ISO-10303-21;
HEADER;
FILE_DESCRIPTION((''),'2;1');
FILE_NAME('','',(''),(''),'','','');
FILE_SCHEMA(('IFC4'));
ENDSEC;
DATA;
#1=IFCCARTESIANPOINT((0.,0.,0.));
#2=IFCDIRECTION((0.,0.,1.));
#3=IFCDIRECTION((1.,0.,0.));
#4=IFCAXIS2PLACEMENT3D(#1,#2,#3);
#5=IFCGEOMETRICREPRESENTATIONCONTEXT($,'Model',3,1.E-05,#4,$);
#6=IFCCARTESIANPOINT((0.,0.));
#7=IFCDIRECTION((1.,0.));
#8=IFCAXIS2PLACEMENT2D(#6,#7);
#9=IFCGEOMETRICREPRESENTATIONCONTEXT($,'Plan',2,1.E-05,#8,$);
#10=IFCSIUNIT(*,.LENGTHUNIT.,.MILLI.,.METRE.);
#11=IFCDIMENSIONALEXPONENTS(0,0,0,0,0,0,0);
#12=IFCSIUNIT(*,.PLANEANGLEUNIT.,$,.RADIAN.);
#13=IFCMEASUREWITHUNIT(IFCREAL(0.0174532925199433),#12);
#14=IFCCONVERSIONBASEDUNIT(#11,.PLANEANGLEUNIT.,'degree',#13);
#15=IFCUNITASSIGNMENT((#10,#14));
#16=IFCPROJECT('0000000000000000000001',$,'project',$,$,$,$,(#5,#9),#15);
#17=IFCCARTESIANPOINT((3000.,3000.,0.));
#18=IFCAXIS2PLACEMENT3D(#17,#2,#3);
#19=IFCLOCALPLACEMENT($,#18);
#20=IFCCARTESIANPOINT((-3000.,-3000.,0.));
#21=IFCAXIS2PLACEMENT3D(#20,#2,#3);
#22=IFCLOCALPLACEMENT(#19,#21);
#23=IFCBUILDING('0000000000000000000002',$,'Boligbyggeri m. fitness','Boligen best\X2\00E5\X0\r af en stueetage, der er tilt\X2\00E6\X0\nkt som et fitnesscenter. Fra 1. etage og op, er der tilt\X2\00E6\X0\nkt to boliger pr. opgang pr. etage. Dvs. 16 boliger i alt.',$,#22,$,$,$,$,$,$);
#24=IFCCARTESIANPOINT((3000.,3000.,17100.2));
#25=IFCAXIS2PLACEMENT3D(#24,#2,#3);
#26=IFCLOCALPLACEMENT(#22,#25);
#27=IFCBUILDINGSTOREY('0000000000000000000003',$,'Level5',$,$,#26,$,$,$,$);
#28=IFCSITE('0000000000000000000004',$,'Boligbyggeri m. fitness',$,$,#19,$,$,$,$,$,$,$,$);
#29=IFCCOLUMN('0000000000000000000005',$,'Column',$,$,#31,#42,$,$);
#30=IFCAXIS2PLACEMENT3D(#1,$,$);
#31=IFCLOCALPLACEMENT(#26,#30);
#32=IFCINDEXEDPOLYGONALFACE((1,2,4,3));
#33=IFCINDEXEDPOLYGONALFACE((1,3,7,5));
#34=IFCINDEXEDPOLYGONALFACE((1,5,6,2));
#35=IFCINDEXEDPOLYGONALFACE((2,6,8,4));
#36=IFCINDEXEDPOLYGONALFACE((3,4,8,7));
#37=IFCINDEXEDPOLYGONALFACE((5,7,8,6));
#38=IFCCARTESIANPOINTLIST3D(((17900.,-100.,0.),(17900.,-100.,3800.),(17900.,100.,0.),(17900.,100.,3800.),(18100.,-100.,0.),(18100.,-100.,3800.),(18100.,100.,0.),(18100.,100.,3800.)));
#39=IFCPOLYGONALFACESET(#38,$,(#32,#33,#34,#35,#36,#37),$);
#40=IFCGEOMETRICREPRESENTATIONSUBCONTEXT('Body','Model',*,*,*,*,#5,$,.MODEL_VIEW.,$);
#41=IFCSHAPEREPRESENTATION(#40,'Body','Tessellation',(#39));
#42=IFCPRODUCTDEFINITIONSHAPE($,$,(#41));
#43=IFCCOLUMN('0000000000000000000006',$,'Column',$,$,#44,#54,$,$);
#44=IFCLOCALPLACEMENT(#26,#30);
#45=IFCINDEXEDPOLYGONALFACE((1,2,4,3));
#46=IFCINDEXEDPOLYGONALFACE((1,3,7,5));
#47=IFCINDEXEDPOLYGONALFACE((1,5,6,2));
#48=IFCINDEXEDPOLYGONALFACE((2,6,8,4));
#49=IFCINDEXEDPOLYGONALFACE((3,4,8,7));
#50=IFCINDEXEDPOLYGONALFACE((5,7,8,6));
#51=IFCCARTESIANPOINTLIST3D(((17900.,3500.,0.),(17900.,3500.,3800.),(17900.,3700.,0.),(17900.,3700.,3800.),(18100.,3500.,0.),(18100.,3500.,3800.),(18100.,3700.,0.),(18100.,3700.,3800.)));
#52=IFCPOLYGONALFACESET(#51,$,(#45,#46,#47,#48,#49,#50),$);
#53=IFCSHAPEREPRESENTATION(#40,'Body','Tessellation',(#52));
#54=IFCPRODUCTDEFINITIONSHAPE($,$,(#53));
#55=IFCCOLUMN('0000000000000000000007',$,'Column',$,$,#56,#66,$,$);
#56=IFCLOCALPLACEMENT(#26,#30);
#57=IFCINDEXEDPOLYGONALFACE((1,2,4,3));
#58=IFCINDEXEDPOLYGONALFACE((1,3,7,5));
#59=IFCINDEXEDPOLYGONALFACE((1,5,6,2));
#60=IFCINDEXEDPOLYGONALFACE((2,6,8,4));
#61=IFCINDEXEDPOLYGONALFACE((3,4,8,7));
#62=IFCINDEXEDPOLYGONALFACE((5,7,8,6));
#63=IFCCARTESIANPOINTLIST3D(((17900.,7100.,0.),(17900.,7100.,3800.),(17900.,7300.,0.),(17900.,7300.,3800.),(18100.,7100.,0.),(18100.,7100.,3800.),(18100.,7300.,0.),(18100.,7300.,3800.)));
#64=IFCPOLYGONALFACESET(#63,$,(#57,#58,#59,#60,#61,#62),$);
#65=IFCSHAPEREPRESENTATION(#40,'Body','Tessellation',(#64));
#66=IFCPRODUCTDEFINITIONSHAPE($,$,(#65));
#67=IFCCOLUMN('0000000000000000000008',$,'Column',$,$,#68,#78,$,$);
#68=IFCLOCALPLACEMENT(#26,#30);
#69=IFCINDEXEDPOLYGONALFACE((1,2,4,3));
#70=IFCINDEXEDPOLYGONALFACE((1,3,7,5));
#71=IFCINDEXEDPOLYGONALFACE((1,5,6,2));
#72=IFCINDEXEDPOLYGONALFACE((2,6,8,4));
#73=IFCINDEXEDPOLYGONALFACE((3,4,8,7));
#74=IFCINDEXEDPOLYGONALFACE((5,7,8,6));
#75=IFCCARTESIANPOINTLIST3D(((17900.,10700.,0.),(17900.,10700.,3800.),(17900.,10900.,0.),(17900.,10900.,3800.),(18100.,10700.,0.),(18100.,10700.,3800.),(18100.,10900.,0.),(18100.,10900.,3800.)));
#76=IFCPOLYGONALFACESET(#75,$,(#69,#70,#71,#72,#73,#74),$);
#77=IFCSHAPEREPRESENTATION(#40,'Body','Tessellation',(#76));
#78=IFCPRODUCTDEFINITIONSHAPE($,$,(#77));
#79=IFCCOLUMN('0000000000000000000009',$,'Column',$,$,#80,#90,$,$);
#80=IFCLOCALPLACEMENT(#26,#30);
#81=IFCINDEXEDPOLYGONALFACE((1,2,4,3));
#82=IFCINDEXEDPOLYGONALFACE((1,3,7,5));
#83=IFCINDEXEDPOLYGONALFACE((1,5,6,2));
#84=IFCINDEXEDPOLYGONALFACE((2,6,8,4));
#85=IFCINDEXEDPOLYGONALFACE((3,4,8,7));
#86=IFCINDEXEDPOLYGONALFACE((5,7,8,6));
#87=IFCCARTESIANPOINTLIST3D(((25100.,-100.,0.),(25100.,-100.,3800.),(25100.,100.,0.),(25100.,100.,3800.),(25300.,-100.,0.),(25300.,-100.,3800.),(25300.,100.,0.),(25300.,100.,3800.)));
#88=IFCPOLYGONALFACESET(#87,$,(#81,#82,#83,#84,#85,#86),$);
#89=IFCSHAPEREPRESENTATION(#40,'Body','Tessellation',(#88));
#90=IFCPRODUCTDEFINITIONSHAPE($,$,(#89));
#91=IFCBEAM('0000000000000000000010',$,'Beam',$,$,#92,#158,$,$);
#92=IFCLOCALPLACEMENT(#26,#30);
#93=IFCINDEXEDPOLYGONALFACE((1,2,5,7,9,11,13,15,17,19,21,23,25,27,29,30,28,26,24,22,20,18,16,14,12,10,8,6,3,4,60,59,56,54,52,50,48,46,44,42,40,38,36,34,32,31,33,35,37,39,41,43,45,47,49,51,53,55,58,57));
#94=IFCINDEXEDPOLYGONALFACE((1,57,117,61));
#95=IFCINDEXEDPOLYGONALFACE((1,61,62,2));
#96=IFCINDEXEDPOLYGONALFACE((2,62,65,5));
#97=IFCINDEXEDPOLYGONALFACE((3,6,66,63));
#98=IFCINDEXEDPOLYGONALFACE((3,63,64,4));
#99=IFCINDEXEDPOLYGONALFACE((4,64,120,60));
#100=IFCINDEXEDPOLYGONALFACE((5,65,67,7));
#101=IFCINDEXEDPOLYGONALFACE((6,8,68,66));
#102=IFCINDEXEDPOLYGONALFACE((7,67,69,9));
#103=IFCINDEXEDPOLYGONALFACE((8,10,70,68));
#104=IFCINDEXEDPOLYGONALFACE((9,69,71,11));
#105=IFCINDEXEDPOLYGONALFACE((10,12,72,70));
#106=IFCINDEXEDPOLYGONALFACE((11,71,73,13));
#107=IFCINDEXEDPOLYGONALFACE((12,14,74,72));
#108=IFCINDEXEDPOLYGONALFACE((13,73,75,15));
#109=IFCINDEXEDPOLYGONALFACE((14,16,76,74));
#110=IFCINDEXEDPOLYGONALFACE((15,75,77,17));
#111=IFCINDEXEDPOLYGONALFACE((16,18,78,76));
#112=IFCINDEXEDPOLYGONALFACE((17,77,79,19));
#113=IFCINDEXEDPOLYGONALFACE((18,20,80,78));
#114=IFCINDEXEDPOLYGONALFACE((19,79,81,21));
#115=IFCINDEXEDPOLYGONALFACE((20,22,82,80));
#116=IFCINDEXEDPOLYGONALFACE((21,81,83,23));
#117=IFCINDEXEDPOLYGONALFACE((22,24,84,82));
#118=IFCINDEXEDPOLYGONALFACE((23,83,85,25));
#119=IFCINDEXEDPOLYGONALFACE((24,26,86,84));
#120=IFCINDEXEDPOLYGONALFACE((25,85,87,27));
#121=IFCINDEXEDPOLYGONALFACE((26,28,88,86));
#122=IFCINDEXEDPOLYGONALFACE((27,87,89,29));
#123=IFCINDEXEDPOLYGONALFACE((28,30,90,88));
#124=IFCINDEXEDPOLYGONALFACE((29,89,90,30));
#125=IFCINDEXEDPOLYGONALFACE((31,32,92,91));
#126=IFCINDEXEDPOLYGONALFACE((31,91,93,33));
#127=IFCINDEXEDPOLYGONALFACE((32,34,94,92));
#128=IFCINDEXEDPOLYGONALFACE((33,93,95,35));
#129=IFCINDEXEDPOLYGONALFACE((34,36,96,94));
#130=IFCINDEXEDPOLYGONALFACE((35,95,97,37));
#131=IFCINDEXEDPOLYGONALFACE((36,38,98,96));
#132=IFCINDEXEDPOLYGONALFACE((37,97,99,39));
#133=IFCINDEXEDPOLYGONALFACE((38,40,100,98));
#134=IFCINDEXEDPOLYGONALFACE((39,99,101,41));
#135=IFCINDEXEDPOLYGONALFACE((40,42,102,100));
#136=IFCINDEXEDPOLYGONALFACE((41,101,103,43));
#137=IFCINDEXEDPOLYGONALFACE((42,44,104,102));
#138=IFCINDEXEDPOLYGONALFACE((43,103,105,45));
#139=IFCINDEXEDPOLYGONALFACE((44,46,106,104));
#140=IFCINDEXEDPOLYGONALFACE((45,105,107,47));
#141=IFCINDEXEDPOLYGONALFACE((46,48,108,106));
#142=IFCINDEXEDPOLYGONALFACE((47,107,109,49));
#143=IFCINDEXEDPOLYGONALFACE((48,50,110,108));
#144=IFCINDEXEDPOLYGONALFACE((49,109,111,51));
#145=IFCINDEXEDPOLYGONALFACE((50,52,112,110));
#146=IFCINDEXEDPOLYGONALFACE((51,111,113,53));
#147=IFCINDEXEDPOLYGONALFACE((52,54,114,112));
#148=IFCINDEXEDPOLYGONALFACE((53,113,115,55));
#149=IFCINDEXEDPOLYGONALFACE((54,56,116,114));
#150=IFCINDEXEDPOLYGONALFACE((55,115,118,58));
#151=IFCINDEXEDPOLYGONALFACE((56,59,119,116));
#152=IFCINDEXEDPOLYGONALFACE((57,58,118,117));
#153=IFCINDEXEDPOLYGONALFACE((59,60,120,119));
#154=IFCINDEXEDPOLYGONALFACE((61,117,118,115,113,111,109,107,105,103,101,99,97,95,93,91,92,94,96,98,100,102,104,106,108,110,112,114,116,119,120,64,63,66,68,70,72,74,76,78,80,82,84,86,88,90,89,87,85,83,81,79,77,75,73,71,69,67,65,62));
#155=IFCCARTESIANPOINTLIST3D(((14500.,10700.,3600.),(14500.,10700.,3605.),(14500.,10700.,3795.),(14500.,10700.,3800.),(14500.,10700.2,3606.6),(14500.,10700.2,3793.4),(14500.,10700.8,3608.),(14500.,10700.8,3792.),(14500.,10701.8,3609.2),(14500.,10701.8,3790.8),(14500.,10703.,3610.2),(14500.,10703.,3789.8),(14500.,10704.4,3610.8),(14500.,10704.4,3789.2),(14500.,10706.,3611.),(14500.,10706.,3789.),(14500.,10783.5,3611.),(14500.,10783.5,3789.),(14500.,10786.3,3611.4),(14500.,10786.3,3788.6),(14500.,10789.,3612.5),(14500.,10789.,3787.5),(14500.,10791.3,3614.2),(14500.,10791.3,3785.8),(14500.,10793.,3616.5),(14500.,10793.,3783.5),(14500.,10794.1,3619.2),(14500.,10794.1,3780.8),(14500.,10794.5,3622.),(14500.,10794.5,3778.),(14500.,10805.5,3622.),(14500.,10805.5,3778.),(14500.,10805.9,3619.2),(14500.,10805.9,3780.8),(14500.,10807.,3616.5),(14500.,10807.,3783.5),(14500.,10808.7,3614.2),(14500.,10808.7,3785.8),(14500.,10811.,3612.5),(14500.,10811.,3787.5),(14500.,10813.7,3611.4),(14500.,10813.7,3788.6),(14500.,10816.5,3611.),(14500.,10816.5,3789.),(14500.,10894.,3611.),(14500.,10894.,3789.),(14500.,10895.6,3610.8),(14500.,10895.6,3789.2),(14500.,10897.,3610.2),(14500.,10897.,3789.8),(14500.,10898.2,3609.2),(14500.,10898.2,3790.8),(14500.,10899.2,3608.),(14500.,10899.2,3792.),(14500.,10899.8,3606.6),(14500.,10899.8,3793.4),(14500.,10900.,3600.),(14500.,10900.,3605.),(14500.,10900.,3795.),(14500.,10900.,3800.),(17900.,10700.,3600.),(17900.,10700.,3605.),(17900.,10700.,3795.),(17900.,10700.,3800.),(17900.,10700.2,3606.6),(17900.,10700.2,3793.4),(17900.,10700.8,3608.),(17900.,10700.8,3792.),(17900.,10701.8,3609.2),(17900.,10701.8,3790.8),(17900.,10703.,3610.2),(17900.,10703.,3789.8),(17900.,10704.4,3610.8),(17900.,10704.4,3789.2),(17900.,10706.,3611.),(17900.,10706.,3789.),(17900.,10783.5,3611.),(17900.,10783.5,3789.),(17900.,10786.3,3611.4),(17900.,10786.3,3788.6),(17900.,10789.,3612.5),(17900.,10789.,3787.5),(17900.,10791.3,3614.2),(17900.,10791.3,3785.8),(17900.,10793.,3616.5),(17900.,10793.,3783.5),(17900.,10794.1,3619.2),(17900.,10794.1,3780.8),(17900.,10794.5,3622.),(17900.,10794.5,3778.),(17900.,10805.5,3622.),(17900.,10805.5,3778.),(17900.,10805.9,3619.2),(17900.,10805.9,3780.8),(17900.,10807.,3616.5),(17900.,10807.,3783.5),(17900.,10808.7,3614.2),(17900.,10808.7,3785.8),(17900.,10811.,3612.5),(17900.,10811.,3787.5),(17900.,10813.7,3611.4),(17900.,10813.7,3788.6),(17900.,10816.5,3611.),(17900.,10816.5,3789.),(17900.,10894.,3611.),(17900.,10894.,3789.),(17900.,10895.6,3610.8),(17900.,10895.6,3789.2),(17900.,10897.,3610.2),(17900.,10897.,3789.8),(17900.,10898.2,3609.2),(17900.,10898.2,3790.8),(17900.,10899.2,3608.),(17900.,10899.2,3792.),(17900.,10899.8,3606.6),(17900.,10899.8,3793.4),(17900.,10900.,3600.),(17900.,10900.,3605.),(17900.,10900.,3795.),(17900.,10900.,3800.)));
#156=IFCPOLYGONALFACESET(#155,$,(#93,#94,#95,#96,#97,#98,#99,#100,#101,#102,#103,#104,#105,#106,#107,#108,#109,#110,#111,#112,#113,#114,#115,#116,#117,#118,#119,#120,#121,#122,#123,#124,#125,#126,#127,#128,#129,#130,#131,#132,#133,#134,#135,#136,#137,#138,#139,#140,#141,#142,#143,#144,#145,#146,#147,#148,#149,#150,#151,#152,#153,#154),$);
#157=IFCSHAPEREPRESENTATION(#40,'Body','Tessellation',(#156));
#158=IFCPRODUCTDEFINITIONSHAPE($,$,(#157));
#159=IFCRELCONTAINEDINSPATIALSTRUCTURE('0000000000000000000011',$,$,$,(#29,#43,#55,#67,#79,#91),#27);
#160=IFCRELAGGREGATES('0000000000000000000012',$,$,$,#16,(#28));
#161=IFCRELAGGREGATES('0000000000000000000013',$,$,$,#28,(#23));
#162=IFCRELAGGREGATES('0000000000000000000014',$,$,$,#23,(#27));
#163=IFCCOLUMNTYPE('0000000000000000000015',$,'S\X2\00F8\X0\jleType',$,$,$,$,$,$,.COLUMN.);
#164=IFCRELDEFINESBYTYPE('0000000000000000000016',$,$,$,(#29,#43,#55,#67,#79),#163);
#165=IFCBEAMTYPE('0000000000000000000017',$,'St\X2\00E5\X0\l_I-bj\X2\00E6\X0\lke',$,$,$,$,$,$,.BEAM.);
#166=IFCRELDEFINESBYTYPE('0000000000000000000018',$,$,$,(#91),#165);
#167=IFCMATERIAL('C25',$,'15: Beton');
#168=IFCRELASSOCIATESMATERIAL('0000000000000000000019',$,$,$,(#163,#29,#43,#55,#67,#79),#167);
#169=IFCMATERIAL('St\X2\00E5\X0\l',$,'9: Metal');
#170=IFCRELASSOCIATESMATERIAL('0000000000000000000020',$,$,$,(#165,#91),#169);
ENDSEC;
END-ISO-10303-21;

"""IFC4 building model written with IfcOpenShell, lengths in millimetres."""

from ifc_helpers import new_model, entity, si_unit, converted_unit, frame, origin_with_axes, origin_2d_with_axis, place, context, subcontext, project, spatial, rectangle, i_section, extrude, material, material_profile, profile_set, profile_usage, type_object, element, save


model = new_model("IFC4")

# Units and contexts
model_context = context("Model", 3, precision=1e-05, world=origin_with_axes())
plan_context = context("Plan", 2, precision=1e-05, world=origin_2d_with_axis())
body_context = subcontext(model_context, "Body", "Model", "MODEL_VIEW")
ifc_project = project(units=[si_unit("LENGTHUNIT", "METRE", prefix="MILLI"), converted_unit("PLANEANGLEUNIT", "degree", entity("IfcReal", 0.0174532925199433), si_unit("PLANEANGLEUNIT", "RADIAN"), dimensions=[0, 0, 0, 0, 0, 0, 0])], contexts=[model_context, plan_context])

# Site, building, storey
site_placement = place(None, frame((3000.0, 3000.0, 0.0), z_axis=(0.0, 0.0, 1.0), x_axis=(1.0, 0.0, 0.0)))
site = spatial("IfcSite", under=ifc_project, at=site_placement, Name="Boligbyggeri m. fitness")
building_placement = place(site_placement, frame((-3000.0, -3000.0, 0.0), z_axis=(0.0, 0.0, 1.0), x_axis=(1.0, 0.0, 0.0)))
building = spatial("IfcBuilding", under=site, at=building_placement, Name="Boligbyggeri m. fitness", Description="Boligen består af en stueetage, der er tiltænkt som et fitnesscenter. Fra 1. etage og op, er der tiltænkt to boliger pr. opgang pr. etage. Dvs. 16 boliger i alt.")
storey_placement = place(building_placement, frame((3000.0, 3000.0, 17100.2), z_axis=(0.0, 0.0, 1.0), x_axis=(1.0, 0.0, 0.0)))
storey = spatial("IfcBuildingStorey", under=building, at=storey_placement, Name="Level5")

# Columns
ifc_material_1 = material(Name="C25", Category="15: Beton")
ifc_material_profile_1 = material_profile(ifc_material_1, rectangle(XDim=200.0, YDim=200.0), Name="SøjleBeton", Category="15: Beton")
ifc_profile_set_1 = profile_set([ifc_material_profile_1], Name="200x200")
ifc_profile_usage_1 = profile_usage(ifc_profile_set_1, cardinal=5)
column_type = type_object("IfcColumnType", Name="SøjleType", PredefinedType="COLUMN", material=ifc_profile_set_1)
column_1_placement = place(storey_placement, frame((18000.0, 0.0, 0.0), z_axis=(0.0, 0.0, 1.0), x_axis=(1.0, 0.0, 0.0)))
element("IfcColumn", 1, at=column_1_placement, inside=storey, type_object=column_type, material=ifc_profile_usage_1, Name="Column", context=body_context, shape_type="SweptSolid", body=[
    extrude(rectangle(XDim=200.0, YDim=200.0), origin_with_axes(), (0.0, 0.0, 1.0), 3800.0),
])
ifc_profile_usage_2 = profile_usage(ifc_profile_set_1, cardinal=5)
column_2_placement = place(storey_placement, frame((18000.0, 3600.0, 0.0), z_axis=(0.0, 0.0, 1.0), x_axis=(1.0, 0.0, 0.0)))
element("IfcColumn", 2, at=column_2_placement, inside=storey, type_object=column_type, material=ifc_profile_usage_2, Name="Column", context=body_context, shape_type="SweptSolid", body=[
    extrude(rectangle(XDim=200.0, YDim=200.0), origin_with_axes(), (0.0, 0.0, 1.0), 3800.0),
])
ifc_profile_usage_3 = profile_usage(ifc_profile_set_1, cardinal=5)
column_3_placement = place(storey_placement, frame((18000.0, 7200.0, 0.0), z_axis=(0.0, 0.0, 1.0), x_axis=(1.0, 0.0, 0.0)))
element("IfcColumn", 3, at=column_3_placement, inside=storey, type_object=column_type, material=ifc_profile_usage_3, Name="Column", context=body_context, shape_type="SweptSolid", body=[
    extrude(rectangle(XDim=200.0, YDim=200.0), origin_with_axes(), (0.0, 0.0, 1.0), 3800.0),
])
ifc_profile_usage_4 = profile_usage(ifc_profile_set_1, cardinal=5)
column_4_placement = place(storey_placement, frame((18000.0, 10800.0, 0.0), z_axis=(0.0, 0.0, 1.0), x_axis=(1.0, 0.0, 0.0)))
element("IfcColumn", 4, at=column_4_placement, inside=storey, type_object=column_type, material=ifc_profile_usage_4, Name="Column", context=body_context, shape_type="SweptSolid", body=[
    extrude(rectangle(XDim=200.0, YDim=200.0), origin_with_axes(), (0.0, 0.0, 1.0), 3800.0),
])
ifc_profile_usage_5 = profile_usage(ifc_profile_set_1, cardinal=5)
column_5_placement = place(storey_placement, frame((25200.0, 0.0, 0.0), z_axis=(0.0, 0.0, 1.0), x_axis=(1.0, 0.0, 0.0)))
element("IfcColumn", 5, at=column_5_placement, inside=storey, type_object=column_type, material=ifc_profile_usage_5, Name="Column", context=body_context, shape_type="SweptSolid", body=[
    extrude(rectangle(XDim=200.0, YDim=200.0), origin_with_axes(), (0.0, 0.0, 1.0), 3800.0),
])

# Beam
ifc_material_2 = material(Name="Stål", Category="9: Metal")
ifc_material_profile_2 = material_profile(ifc_material_2, i_section(OverallWidth=200.0, OverallDepth=200.0, WebThickness=11.0, FlangeThickness=11.0, FilletRadius=11.0, FlangeEdgeRadius=6.0), Name="Stål", Category="9: Metal")
ifc_profile_set_2 = profile_set([ifc_material_profile_2], Name="NY_I-Profil")
ifc_profile_usage_6 = profile_usage(ifc_profile_set_2, cardinal=7)
beam_type = type_object("IfcBeamType", Name="Stål_I-bjælke", PredefinedType="BEAM", material=ifc_profile_set_2)
beam_1_placement = place(storey_placement, frame((14500.0, 10900.0, 3800.0), z_axis=(1.0, 0.0, 0.0), x_axis=(0.0, 1.0, 0.0)))
element("IfcBeam", 6, at=beam_1_placement, inside=storey, type_object=beam_type, material=ifc_profile_usage_6, Name="Beam", context=body_context, shape_type="SweptSolid", body=[
    extrude(i_section(OverallWidth=200.0, OverallDepth=200.0, WebThickness=11.0, FlangeThickness=11.0, FilletRadius=11.0, FlangeEdgeRadius=6.0), frame((-100.0, -100.0, 0.0), z_axis=(0.0, 0.0, 1.0), x_axis=(1.0, 0.0, 0.0)), (0.0, 0.0, 1.0), 3400.0),
])

save(model, "model.ifc")
